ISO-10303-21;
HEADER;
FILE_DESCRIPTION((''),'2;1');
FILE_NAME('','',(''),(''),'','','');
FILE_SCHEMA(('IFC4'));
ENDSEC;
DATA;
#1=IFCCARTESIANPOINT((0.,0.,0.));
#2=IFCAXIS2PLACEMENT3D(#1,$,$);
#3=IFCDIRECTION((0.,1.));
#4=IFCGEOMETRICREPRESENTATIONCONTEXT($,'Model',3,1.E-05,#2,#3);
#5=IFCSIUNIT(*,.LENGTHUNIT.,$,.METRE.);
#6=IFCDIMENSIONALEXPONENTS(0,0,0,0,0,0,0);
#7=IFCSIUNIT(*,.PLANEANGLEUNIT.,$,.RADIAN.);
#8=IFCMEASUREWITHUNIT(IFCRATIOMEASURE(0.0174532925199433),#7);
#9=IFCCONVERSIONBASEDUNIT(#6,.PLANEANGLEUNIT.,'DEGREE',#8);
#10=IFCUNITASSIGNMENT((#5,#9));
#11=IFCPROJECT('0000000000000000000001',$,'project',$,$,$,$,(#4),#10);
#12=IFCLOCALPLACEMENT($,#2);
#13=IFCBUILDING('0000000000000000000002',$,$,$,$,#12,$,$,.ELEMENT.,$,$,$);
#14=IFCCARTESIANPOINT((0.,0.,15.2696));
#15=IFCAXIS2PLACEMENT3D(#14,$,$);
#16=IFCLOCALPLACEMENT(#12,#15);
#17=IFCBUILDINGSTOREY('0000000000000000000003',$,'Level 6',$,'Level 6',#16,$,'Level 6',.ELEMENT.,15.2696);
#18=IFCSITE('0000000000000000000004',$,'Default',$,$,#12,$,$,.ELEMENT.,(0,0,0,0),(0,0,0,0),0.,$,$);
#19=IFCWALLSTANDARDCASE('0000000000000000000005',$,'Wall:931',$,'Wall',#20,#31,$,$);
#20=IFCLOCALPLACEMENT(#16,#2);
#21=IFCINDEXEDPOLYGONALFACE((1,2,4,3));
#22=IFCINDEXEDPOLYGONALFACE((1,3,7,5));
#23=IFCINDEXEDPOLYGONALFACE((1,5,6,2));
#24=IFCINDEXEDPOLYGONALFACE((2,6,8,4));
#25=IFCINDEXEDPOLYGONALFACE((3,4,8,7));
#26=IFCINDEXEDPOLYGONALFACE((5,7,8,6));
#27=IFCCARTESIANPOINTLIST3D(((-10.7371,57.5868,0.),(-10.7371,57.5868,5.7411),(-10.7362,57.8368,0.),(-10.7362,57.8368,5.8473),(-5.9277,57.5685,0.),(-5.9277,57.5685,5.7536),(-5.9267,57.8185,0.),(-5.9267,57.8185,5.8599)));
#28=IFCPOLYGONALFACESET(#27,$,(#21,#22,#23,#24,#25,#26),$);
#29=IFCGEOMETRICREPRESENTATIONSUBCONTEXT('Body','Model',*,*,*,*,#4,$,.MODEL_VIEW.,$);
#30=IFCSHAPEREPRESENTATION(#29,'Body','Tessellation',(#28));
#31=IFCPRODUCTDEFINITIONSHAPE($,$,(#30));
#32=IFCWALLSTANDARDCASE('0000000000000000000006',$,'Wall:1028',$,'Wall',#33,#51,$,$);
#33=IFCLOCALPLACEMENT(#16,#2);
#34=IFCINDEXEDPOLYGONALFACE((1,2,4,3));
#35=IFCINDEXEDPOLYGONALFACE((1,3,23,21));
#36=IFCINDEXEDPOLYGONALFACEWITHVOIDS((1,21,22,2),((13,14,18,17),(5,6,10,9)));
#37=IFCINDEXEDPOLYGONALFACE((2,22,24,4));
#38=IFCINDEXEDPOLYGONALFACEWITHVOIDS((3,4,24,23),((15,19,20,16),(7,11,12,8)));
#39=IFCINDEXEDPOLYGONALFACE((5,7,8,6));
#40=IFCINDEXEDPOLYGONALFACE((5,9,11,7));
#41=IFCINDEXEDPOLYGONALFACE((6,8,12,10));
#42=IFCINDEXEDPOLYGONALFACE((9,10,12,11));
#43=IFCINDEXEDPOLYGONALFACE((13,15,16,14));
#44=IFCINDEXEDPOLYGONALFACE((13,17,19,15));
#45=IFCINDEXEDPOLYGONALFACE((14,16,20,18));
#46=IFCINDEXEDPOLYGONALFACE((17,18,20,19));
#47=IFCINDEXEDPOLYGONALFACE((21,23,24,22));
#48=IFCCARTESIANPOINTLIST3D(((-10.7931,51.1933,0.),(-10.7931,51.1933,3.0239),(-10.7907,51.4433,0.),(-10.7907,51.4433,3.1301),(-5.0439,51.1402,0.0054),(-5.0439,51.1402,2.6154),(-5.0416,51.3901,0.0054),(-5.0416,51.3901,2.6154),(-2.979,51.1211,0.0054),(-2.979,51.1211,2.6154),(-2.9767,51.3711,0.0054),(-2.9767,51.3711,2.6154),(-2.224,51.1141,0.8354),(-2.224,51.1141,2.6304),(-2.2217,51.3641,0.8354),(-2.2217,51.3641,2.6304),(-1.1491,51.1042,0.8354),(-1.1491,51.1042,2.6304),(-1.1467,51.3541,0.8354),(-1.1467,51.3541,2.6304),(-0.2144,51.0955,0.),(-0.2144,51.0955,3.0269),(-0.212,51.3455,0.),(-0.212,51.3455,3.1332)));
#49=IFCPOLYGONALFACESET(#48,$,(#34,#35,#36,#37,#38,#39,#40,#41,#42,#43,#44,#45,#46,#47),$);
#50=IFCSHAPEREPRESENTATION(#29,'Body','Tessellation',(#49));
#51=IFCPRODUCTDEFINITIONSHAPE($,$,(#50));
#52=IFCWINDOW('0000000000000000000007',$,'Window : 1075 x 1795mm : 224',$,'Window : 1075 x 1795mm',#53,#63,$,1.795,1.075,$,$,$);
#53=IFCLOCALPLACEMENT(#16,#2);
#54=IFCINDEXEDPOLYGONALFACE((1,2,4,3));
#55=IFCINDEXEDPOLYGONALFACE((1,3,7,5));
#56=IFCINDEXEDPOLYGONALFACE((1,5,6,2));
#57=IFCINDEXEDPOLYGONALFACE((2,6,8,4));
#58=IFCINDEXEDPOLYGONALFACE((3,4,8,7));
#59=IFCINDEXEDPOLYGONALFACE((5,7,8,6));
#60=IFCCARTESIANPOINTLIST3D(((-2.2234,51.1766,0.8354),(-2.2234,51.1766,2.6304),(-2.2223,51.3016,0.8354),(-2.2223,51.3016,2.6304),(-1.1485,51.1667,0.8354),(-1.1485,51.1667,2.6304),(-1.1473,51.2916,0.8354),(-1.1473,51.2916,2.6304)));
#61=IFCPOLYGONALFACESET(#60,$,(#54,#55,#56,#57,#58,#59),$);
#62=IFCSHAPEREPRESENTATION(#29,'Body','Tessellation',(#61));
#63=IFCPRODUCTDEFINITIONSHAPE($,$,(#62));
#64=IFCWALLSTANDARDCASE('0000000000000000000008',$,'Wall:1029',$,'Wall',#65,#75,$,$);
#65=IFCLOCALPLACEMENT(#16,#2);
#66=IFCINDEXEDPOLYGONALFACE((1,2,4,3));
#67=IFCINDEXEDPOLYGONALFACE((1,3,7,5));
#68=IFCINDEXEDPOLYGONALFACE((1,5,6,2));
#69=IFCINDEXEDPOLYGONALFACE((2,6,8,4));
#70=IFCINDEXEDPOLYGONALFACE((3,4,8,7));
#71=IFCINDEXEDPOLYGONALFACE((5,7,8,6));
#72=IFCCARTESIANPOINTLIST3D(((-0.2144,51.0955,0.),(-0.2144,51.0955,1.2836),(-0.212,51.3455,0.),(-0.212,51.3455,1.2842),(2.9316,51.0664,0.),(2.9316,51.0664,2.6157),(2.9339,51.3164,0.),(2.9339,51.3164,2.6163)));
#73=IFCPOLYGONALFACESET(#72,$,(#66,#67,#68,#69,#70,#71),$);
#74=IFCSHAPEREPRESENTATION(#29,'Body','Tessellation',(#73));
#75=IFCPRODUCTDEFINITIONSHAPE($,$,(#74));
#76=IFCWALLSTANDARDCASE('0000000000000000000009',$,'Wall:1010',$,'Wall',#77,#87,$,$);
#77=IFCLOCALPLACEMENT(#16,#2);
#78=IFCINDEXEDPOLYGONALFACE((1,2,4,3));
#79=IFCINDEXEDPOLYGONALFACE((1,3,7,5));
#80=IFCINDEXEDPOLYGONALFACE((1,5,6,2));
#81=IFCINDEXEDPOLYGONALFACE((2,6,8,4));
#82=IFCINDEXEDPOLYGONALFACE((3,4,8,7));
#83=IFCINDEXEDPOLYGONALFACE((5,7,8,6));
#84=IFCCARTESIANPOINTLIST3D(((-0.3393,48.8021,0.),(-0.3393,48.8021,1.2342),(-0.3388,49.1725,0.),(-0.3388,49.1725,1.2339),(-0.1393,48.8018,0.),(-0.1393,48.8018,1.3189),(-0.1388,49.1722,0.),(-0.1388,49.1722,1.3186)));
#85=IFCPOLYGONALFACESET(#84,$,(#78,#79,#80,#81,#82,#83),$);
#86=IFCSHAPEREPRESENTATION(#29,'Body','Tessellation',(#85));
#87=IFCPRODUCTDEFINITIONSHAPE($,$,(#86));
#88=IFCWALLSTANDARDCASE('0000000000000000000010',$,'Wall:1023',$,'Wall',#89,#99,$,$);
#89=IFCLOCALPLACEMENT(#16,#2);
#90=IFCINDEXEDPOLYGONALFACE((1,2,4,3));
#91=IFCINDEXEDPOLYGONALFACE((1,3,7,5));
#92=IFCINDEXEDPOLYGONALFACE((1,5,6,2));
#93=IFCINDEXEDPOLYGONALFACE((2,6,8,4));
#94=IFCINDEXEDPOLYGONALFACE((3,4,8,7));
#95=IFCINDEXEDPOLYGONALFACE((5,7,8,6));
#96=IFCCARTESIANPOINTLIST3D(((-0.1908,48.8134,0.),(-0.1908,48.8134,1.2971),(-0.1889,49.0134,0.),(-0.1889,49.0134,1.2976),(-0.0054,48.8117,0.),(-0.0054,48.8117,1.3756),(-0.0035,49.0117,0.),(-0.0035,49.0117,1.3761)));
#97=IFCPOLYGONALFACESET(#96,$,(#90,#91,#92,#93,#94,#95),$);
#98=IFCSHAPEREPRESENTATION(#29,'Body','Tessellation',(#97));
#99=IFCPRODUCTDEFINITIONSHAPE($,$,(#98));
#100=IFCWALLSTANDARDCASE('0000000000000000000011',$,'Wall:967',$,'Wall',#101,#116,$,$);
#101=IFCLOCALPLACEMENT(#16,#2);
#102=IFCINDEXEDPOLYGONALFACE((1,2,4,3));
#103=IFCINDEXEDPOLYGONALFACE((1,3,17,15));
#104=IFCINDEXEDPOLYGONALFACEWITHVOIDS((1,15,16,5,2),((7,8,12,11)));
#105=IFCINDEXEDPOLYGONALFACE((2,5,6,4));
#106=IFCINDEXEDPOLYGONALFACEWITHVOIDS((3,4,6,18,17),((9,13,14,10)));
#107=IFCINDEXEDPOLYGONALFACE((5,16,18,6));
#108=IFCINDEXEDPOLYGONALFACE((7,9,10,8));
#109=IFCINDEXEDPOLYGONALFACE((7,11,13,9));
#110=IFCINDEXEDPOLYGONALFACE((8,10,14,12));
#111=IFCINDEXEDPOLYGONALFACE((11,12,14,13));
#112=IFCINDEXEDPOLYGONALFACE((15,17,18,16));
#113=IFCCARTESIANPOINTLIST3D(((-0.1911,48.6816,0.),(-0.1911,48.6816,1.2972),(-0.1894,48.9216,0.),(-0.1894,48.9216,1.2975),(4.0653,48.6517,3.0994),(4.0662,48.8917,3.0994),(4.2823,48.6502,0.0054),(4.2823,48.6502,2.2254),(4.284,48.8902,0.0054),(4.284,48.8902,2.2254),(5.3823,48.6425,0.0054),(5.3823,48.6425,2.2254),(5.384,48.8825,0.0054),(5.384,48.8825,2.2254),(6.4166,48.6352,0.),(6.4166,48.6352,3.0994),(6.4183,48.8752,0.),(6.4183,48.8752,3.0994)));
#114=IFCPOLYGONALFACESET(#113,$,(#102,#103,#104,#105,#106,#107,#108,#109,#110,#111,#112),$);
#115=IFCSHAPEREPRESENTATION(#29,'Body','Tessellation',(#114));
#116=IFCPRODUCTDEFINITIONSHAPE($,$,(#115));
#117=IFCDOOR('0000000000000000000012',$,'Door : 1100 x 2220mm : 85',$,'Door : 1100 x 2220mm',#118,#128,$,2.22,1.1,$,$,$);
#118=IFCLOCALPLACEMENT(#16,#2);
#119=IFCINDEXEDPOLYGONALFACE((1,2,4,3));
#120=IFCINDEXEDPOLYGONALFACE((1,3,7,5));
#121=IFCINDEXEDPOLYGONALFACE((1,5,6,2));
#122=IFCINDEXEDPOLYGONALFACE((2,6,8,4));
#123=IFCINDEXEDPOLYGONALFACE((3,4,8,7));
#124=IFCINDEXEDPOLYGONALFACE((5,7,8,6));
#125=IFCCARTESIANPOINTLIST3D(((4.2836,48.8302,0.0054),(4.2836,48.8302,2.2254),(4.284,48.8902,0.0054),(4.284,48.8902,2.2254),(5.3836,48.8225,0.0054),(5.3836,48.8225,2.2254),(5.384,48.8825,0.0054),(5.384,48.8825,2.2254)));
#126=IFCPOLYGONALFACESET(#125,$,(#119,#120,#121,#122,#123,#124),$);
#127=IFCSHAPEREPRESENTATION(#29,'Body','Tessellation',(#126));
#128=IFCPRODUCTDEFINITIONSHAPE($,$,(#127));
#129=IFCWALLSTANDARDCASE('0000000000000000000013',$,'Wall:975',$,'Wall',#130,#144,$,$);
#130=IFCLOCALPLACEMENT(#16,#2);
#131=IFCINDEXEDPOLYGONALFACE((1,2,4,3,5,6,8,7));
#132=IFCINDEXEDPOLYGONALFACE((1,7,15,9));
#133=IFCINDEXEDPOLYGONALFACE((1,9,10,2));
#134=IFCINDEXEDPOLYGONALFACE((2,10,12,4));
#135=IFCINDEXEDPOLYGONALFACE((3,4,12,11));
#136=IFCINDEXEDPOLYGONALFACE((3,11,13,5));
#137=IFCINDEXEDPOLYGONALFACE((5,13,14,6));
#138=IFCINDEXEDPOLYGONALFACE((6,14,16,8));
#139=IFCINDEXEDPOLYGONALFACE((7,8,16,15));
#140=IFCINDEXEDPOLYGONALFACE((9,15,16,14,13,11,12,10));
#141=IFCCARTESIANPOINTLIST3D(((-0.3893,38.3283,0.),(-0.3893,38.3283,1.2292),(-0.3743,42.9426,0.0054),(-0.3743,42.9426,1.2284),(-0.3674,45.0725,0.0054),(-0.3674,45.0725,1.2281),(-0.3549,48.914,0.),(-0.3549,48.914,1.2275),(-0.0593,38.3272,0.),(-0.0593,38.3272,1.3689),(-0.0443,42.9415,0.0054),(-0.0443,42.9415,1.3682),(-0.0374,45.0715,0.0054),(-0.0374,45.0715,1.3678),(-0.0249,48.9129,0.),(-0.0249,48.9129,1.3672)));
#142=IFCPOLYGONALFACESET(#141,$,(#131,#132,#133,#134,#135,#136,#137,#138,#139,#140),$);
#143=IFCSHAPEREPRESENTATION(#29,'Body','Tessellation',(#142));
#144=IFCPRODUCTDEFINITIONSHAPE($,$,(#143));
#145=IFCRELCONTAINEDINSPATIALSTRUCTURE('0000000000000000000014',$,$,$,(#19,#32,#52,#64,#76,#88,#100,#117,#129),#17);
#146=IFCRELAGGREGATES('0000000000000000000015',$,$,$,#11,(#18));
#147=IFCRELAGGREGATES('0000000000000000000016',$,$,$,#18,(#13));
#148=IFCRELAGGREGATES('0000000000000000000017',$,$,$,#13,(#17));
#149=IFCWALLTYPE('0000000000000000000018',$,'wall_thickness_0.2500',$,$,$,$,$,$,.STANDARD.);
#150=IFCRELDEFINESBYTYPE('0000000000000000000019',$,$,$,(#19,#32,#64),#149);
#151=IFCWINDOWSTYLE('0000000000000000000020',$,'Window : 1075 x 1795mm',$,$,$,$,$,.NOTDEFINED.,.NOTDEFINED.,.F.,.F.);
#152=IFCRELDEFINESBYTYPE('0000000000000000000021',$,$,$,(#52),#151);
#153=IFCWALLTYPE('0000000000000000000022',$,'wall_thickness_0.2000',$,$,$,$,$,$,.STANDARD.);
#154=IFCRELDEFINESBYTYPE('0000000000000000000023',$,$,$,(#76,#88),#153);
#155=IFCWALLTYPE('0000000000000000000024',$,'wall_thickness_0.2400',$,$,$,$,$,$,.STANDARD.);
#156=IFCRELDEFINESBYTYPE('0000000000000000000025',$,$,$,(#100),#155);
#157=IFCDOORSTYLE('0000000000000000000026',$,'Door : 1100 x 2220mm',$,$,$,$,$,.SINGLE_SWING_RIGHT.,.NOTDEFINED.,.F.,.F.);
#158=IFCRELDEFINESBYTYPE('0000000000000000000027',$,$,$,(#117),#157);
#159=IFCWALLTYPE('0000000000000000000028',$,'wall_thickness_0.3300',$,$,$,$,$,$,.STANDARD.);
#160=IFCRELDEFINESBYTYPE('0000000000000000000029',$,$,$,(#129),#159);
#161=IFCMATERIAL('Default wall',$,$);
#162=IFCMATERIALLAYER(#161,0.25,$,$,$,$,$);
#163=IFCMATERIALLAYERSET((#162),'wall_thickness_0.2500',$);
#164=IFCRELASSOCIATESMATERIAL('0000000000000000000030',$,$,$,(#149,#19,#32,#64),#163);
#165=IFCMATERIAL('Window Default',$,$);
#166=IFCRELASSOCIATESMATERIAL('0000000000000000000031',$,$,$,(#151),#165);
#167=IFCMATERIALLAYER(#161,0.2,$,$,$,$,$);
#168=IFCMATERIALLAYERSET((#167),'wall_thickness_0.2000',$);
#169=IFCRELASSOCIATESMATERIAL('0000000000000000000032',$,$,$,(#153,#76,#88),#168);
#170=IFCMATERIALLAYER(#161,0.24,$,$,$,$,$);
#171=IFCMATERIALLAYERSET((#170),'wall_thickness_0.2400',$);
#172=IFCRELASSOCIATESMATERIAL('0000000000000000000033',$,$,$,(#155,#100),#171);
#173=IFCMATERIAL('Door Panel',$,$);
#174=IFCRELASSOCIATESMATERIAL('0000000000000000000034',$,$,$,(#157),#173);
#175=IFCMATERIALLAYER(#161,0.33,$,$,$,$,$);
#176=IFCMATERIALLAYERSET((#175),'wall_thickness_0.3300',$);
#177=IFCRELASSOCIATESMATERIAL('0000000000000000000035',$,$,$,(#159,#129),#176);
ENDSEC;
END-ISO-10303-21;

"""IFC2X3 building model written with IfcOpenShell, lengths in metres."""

from ifc_helpers import new_model, entity, si_unit, converted_unit, direction, frame, frame_2d, origin, origin_2d_with_axis, place, context, subcontext, project, spatial, polyline, rectangle, outline, extrude, clip, halfspace, source, transform, mapped, material, layer, layer_set, layer_usage, type_object, type_shapes, element, fill, save


model = new_model("IFC2X3")

# Units and contexts
model_context = context("Model", 3, precision=1e-05, world=origin(), true_north=direction((0.0, 1.0)))
body_context = subcontext(model_context, "Body", "Model", "MODEL_VIEW")
ifc_project = project(units=[si_unit("LENGTHUNIT", "METRE"), converted_unit("PLANEANGLEUNIT", "DEGREE", entity("IfcRatioMeasure", 0.0174532925199433), si_unit("PLANEANGLEUNIT", "RADIAN"), dimensions=[0, 0, 0, 0, 0, 0, 0])], contexts=[model_context])

# Site, building, storey
placement = place(None, origin())
site = spatial("IfcSite", under=ifc_project, at=placement, Name="Default", CompositionType="ELEMENT", RefLatitude=(0, 0, 0, 0), RefLongitude=(0, 0, 0, 0), RefElevation=0.0)
building = spatial("IfcBuilding", under=site, at=placement, CompositionType="ELEMENT")
storey_placement = place(placement, frame((0.0, 0.0, 15.2696)))
storey = spatial("IfcBuildingStorey", under=building, at=storey_placement, Name="Level 6", ObjectType="Level 6", LongName="Level 6", CompositionType="ELEMENT", Elevation=15.2696)

# Wall
ifc_material_1 = material(Name="Default wall")
ifc_layer_1 = layer(ifc_material_1, 0.25)
ifc_layer_set_1 = layer_set([ifc_layer_1], Name="wall_thickness_0.2500")
ifc_layer_usage_1 = layer_usage(ifc_layer_set_1, "AXIS2", "POSITIVE", -0.125)
wall_type_1 = type_object("IfcWallType", Name="wall_thickness_0.2500", PredefinedType="STANDARD", material=ifc_layer_set_1)
wall_1_placement = place(storey_placement, frame((-10.7367, 57.7118, 0.0), z_axis=(0.0, 0.0, 1.0), x_axis=(0.999993, -0.003799, 0.0)))
element("IfcWallStandardCase", 1, at=wall_1_placement, inside=storey, type_object=wall_type_1, material=ifc_layer_usage_1, Name="Wall:931", ObjectType="Wall", context=body_context, shape_type="Clipping", body=[
    clip(extrude(outline(polyline([(4.8095, -0.125), (4.8095, 0.125), (0.0, 0.125), (0.0, -0.125), (4.8095, -0.125)])), origin(), (0.0, 0.0, 1.0), 6.0254), halfspace(frame((-2.0169, 0.0877, 5.8262), z_axis=(-0.002399, -0.391121, 0.920336), x_axis=(0.99999, -0.004346, 0.000759)), False)),
])

# Wall, openings, window
wall_2_placement = place(storey_placement, frame((-10.7919, 51.3183, 0.0), z_axis=(0.0, 0.0, 1.0), x_axis=(0.999957, -0.009244, 0.0)))
wall_2 = element("IfcWallStandardCase", 2, at=wall_2_placement, inside=storey, type_object=wall_type_1, material=ifc_layer_usage_1, Name="Wall:1028", ObjectType="Wall", context=body_context, shape_type="Clipping", body=[
    clip(extrude(outline(polyline([(10.5792, -0.125), (10.5792, 0.125), (0.0, 0.125), (0.0, -0.125), (10.5792, -0.125)])), origin(), (0.0, 0.0, 1.0), 3.1754), halfspace(frame((-2.0212, 6.4704, 5.8262), z_axis=(-0.000269, -0.391129, 0.920336), x_axis=(0.999999, 0.001099, 0.000759)), False)),
])
opening_1_placement = place(wall_2_placement, frame((5.7494, -0.125, 0.0054)))
element("IfcOpeningElement", 3, at=opening_1_placement, cuts=wall_2, ObjectType="Opening", context=body_context, shape_type="SweptSolid", body=[
    extrude(rectangle(XDim=2.065, YDim=2.61, at=frame_2d((1.305, 1.0325), x_axis=(0.0, 1.0))), frame((0.0, 0.0, 0.0), z_axis=(0.0, 1.0, 0.0), x_axis=(0.0, 0.0, 1.0)), (0.0, 0.0, 1.0), 0.25),
])
opening_2_placement = place(wall_2_placement, frame((8.5694, -0.125, 0.8354)))
opening_2 = element("IfcOpeningElement", 4, at=opening_2_placement, cuts=wall_2, ObjectType="Opening", context=body_context, shape_type="SweptSolid", body=[
    extrude(rectangle(XDim=1.075, YDim=1.795, at=frame_2d((0.8975, 0.5375), x_axis=(0.0, 1.0))), frame((0.0, 0.0, 0.0), z_axis=(0.0, 1.0, 0.0), x_axis=(0.0, 0.0, 1.0)), (0.0, 0.0, 1.0), 0.25),
])
ifc_material_2 = material(Name="Window Default")
window_style_1 = type_object("IfcWindowStyle", Name="Window : 1075 x 1795mm", ConstructionType="NOTDEFINED", OperationType="NOTDEFINED", ParameterTakesPrecedence=False, Sizeable=False, material=ifc_material_2)
shared_shape_1 = source(origin(), body_context, "Body", "SweptSolid", [
    extrude(rectangle(XDim=0.125, YDim=1.075, at=origin_2d_with_axis()), frame((0.5375, 0.125, 0.0), z_axis=(0.0, 0.0, 1.0), x_axis=(0.0, 1.0, 0.0)), (0.0, 0.0, 1.0), 1.795),
])
type_shapes(window_style_1, [shared_shape_1])
window_1_placement = place(opening_2_placement, origin())
window_1 = element("IfcWindow", 5, at=window_1_placement, inside=storey, type_object=window_style_1, Name="Window : 1075 x 1795mm : 224", ObjectType="Window : 1075 x 1795mm", OverallHeight=1.795, OverallWidth=1.075, context=body_context, shape_type="MappedRepresentation", body=[
    mapped(shared_shape_1, transform((0.0, 0.0, 0.0), scale=1.0)),
])
fill(opening_2, window_1)

# Walls
wall_3_placement = place(storey_placement, frame((-0.2132, 51.2205, 0.0), z_axis=(0.0, 0.0, 1.0), x_axis=(0.999957, -0.009246, 0.0)))
element("IfcWallStandardCase", 6, at=wall_3_placement, inside=storey, type_object=wall_type_1, material=ifc_layer_usage_1, Name="Wall:1029", ObjectType="Wall", context=body_context, shape_type="Clipping", body=[
    clip(clip(extrude(outline(polyline([(3.1461, -0.125), (3.1461, 0.125), (0.0, 0.125), (0.0, -0.125), (3.1461, -0.125)])), origin(), (0.0, 0.0, 1.0), 3.1754), halfspace(frame((-1.2411, 24.6168, 0.817), z_axis=(-0.389898, -0.00219, 0.920856), x_axis=(0.92085, 0.002961, 0.389905)), False)), halfspace(frame((-12.6004, 6.4704, 5.8262), z_axis=(-0.000268, -0.391129, 0.920336), x_axis=(0.999999, 0.0011, 0.000759)), False)),
])
ifc_layer_2 = layer(ifc_material_1, 0.2)
ifc_layer_set_2 = layer_set([ifc_layer_2], Name="wall_thickness_0.2000")
ifc_layer_usage_2 = layer_usage(ifc_layer_set_2, "AXIS2", "POSITIVE", -0.1)
wall_type_2 = type_object("IfcWallType", Name="wall_thickness_0.2000", PredefinedType="STANDARD", material=ifc_layer_set_2)
wall_4_placement = place(storey_placement, frame((-0.2388, 49.1724, 0.0), z_axis=(0.0, 0.0, 1.0), x_axis=(-0.001421, -0.999999, 0.0)))
element("IfcWallStandardCase", 7, at=wall_4_placement, inside=storey, type_object=wall_type_2, material=ifc_layer_usage_2, Name="Wall:1010", ObjectType="Wall", context=body_context, shape_type="Clipping", body=[
    clip(extrude(outline(polyline([(0.3704, -0.1), (0.3704, 0.1), (0.0, 0.1), (0.0, -0.1), (0.3704, -0.1)])), origin(), (0.0, 0.0, 1.0), 2.6734), halfspace(frame((-26.6739, -1.0258, 0.817), z_axis=(-0.000861, -0.389903, 0.920856), x_axis=(0.004245, 0.920845, 0.389905)), False)),
])
wall_5_placement = place(storey_placement, frame((-0.1899, 48.9134, 0.0), z_axis=(0.0, 0.0, 1.0), x_axis=(0.999956, -0.00934, 0.0)))
element("IfcWallStandardCase", 8, at=wall_5_placement, inside=storey, type_object=wall_type_2, material=ifc_layer_usage_2, Name="Wall:1023", ObjectType="Wall", context=body_context, shape_type="Clipping", body=[
    clip(extrude(outline(polyline([(0.1854, -0.1), (0.1854, 0.1), (0.0, 0.1), (0.0, -0.1), (0.1854, -0.1)])), origin(), (0.0, 0.0, 1.0), 2.8014), halfspace(frame((-1.2883, 26.9234, 0.817), z_axis=(-0.389897, -0.002227, 0.920856), x_axis=(0.92085, 0.003047, 0.389905)), False)),
])

# Wall, opening, door
ifc_layer_3 = layer(ifc_material_1, 0.24)
ifc_layer_set_3 = layer_set([ifc_layer_3], Name="wall_thickness_0.2400")
ifc_layer_usage_3 = layer_usage(ifc_layer_set_3, "AXIS2", "POSITIVE", -0.12)
wall_type_3 = type_object("IfcWallType", Name="wall_thickness_0.2400", PredefinedType="STANDARD", material=ifc_layer_set_3)
wall_6_placement = place(storey_placement, frame((-0.1902, 48.8016, 0.0), z_axis=(0.0, 0.0, 1.0), x_axis=(0.999975, -0.007029, 0.0)))
wall_6 = element("IfcWallStandardCase", 9, at=wall_6_placement, inside=storey, type_object=wall_type_3, material=ifc_layer_usage_3, Name="Wall:967", ObjectType="Wall", context=body_context, shape_type="Clipping", body=[
    clip(extrude(outline(polyline([(6.6078, -0.12), (6.6078, 0.12), (0.0, 0.12), (0.0, -0.12), (6.6078, -0.12)])), origin(), (0.0, 0.0, 1.0), 3.0994), halfspace(frame((-1.2265, 27.0381, 0.817), z_axis=(-0.389901, -0.001326, 0.920856), x_axis=(0.920855, 0.000919, 0.389905)), False)),
])
opening_3_placement = place(wall_6_placement, frame((4.4735, -0.12, 0.0054)))
opening_3 = element("IfcOpeningElement", 10, at=opening_3_placement, cuts=wall_6, ObjectType="Opening", context=body_context, shape_type="SweptSolid", body=[
    extrude(rectangle(XDim=1.1, YDim=2.22, at=frame_2d((1.11, 0.55), x_axis=(0.0, 1.0))), frame((0.0, 0.0, 0.0), z_axis=(0.0, 1.0, 0.0), x_axis=(0.0, 0.0, 1.0)), (0.0, 0.0, 1.0), 0.24),
])
ifc_material_3 = material(Name="Door Panel")
door_style = type_object("IfcDoorStyle", Name="Door : 1100 x 2220mm", ConstructionType="NOTDEFINED", OperationType="SINGLE_SWING_RIGHT", ParameterTakesPrecedence=False, Sizeable=False, material=ifc_material_3)
shared_shape_2 = source(origin(), body_context, "Body", "SweptSolid", [
    extrude(rectangle(XDim=0.06, YDim=1.1, at=origin_2d_with_axis()), frame((0.55, 0.21, 0.0), z_axis=(0.0, 0.0, 1.0), x_axis=(0.0, 1.0, 0.0)), (0.0, 0.0, 1.0), 2.22),
])
type_shapes(door_style, [shared_shape_2])
door_placement = place(opening_3_placement, origin())
door = element("IfcDoor", 11, at=door_placement, inside=storey, type_object=door_style, Name="Door : 1100 x 2220mm : 85", ObjectType="Door : 1100 x 2220mm", OverallHeight=2.22, OverallWidth=1.1, context=body_context, shape_type="MappedRepresentation", body=[
    mapped(shared_shape_2, transform((0.0, 0.0, 0.0), scale=1.0)),
])
fill(opening_3, door)

# Wall, opening
ifc_layer_4 = layer(ifc_material_1, 0.33)
ifc_layer_set_4 = layer_set([ifc_layer_4], Name="wall_thickness_0.3300")
ifc_layer_usage_4 = layer_usage(ifc_layer_set_4, "AXIS2", "POSITIVE", -0.165)
wall_type_4 = type_object("IfcWallType", Name="wall_thickness_0.3300", PredefinedType="STANDARD", material=ifc_layer_set_4)
wall_7_placement = place(storey_placement, frame((-0.1899, 48.9134, 0.0), z_axis=(0.0, 0.0, 1.0), x_axis=(-0.003252, -0.999995, 0.0)))
wall_7 = element("IfcWallStandardCase", 12, at=wall_7_placement, inside=storey, type_object=wall_type_4, material=ifc_layer_usage_4, Name="Wall:975", ObjectType="Wall", context=body_context, shape_type="Clipping", body=[
    clip(extrude(outline(polyline([(10.5857, -0.165), (10.5857, 0.165), (0.0, 0.165), (0.0, -0.165), (10.5857, -0.165)])), origin(), (0.0, 0.0, 1.0), 3.1754), halfspace(frame((-26.9308, -1.1243, 0.817), z_axis=(-0.000147, -0.389904, 0.920856), x_axis=(0.002559, 0.920852, 0.389905)), False)),
])
opening_4_placement = place(wall_7_placement, frame((3.8414, -0.165, 0.0054)))
element("IfcOpeningElement", 13, at=opening_4_placement, cuts=wall_7, ObjectType="Opening", context=body_context, shape_type="SweptSolid", body=[
    extrude(rectangle(XDim=2.13, YDim=2.655, at=frame_2d((1.3275, 1.065), x_axis=(0.0, 1.0))), frame((0.0, 0.0, 0.0), z_axis=(0.0, 1.0, 0.0), x_axis=(0.0, 0.0, 1.0)), (0.0, 0.0, 1.0), 0.33),
])

save(model, "model.ifc")
